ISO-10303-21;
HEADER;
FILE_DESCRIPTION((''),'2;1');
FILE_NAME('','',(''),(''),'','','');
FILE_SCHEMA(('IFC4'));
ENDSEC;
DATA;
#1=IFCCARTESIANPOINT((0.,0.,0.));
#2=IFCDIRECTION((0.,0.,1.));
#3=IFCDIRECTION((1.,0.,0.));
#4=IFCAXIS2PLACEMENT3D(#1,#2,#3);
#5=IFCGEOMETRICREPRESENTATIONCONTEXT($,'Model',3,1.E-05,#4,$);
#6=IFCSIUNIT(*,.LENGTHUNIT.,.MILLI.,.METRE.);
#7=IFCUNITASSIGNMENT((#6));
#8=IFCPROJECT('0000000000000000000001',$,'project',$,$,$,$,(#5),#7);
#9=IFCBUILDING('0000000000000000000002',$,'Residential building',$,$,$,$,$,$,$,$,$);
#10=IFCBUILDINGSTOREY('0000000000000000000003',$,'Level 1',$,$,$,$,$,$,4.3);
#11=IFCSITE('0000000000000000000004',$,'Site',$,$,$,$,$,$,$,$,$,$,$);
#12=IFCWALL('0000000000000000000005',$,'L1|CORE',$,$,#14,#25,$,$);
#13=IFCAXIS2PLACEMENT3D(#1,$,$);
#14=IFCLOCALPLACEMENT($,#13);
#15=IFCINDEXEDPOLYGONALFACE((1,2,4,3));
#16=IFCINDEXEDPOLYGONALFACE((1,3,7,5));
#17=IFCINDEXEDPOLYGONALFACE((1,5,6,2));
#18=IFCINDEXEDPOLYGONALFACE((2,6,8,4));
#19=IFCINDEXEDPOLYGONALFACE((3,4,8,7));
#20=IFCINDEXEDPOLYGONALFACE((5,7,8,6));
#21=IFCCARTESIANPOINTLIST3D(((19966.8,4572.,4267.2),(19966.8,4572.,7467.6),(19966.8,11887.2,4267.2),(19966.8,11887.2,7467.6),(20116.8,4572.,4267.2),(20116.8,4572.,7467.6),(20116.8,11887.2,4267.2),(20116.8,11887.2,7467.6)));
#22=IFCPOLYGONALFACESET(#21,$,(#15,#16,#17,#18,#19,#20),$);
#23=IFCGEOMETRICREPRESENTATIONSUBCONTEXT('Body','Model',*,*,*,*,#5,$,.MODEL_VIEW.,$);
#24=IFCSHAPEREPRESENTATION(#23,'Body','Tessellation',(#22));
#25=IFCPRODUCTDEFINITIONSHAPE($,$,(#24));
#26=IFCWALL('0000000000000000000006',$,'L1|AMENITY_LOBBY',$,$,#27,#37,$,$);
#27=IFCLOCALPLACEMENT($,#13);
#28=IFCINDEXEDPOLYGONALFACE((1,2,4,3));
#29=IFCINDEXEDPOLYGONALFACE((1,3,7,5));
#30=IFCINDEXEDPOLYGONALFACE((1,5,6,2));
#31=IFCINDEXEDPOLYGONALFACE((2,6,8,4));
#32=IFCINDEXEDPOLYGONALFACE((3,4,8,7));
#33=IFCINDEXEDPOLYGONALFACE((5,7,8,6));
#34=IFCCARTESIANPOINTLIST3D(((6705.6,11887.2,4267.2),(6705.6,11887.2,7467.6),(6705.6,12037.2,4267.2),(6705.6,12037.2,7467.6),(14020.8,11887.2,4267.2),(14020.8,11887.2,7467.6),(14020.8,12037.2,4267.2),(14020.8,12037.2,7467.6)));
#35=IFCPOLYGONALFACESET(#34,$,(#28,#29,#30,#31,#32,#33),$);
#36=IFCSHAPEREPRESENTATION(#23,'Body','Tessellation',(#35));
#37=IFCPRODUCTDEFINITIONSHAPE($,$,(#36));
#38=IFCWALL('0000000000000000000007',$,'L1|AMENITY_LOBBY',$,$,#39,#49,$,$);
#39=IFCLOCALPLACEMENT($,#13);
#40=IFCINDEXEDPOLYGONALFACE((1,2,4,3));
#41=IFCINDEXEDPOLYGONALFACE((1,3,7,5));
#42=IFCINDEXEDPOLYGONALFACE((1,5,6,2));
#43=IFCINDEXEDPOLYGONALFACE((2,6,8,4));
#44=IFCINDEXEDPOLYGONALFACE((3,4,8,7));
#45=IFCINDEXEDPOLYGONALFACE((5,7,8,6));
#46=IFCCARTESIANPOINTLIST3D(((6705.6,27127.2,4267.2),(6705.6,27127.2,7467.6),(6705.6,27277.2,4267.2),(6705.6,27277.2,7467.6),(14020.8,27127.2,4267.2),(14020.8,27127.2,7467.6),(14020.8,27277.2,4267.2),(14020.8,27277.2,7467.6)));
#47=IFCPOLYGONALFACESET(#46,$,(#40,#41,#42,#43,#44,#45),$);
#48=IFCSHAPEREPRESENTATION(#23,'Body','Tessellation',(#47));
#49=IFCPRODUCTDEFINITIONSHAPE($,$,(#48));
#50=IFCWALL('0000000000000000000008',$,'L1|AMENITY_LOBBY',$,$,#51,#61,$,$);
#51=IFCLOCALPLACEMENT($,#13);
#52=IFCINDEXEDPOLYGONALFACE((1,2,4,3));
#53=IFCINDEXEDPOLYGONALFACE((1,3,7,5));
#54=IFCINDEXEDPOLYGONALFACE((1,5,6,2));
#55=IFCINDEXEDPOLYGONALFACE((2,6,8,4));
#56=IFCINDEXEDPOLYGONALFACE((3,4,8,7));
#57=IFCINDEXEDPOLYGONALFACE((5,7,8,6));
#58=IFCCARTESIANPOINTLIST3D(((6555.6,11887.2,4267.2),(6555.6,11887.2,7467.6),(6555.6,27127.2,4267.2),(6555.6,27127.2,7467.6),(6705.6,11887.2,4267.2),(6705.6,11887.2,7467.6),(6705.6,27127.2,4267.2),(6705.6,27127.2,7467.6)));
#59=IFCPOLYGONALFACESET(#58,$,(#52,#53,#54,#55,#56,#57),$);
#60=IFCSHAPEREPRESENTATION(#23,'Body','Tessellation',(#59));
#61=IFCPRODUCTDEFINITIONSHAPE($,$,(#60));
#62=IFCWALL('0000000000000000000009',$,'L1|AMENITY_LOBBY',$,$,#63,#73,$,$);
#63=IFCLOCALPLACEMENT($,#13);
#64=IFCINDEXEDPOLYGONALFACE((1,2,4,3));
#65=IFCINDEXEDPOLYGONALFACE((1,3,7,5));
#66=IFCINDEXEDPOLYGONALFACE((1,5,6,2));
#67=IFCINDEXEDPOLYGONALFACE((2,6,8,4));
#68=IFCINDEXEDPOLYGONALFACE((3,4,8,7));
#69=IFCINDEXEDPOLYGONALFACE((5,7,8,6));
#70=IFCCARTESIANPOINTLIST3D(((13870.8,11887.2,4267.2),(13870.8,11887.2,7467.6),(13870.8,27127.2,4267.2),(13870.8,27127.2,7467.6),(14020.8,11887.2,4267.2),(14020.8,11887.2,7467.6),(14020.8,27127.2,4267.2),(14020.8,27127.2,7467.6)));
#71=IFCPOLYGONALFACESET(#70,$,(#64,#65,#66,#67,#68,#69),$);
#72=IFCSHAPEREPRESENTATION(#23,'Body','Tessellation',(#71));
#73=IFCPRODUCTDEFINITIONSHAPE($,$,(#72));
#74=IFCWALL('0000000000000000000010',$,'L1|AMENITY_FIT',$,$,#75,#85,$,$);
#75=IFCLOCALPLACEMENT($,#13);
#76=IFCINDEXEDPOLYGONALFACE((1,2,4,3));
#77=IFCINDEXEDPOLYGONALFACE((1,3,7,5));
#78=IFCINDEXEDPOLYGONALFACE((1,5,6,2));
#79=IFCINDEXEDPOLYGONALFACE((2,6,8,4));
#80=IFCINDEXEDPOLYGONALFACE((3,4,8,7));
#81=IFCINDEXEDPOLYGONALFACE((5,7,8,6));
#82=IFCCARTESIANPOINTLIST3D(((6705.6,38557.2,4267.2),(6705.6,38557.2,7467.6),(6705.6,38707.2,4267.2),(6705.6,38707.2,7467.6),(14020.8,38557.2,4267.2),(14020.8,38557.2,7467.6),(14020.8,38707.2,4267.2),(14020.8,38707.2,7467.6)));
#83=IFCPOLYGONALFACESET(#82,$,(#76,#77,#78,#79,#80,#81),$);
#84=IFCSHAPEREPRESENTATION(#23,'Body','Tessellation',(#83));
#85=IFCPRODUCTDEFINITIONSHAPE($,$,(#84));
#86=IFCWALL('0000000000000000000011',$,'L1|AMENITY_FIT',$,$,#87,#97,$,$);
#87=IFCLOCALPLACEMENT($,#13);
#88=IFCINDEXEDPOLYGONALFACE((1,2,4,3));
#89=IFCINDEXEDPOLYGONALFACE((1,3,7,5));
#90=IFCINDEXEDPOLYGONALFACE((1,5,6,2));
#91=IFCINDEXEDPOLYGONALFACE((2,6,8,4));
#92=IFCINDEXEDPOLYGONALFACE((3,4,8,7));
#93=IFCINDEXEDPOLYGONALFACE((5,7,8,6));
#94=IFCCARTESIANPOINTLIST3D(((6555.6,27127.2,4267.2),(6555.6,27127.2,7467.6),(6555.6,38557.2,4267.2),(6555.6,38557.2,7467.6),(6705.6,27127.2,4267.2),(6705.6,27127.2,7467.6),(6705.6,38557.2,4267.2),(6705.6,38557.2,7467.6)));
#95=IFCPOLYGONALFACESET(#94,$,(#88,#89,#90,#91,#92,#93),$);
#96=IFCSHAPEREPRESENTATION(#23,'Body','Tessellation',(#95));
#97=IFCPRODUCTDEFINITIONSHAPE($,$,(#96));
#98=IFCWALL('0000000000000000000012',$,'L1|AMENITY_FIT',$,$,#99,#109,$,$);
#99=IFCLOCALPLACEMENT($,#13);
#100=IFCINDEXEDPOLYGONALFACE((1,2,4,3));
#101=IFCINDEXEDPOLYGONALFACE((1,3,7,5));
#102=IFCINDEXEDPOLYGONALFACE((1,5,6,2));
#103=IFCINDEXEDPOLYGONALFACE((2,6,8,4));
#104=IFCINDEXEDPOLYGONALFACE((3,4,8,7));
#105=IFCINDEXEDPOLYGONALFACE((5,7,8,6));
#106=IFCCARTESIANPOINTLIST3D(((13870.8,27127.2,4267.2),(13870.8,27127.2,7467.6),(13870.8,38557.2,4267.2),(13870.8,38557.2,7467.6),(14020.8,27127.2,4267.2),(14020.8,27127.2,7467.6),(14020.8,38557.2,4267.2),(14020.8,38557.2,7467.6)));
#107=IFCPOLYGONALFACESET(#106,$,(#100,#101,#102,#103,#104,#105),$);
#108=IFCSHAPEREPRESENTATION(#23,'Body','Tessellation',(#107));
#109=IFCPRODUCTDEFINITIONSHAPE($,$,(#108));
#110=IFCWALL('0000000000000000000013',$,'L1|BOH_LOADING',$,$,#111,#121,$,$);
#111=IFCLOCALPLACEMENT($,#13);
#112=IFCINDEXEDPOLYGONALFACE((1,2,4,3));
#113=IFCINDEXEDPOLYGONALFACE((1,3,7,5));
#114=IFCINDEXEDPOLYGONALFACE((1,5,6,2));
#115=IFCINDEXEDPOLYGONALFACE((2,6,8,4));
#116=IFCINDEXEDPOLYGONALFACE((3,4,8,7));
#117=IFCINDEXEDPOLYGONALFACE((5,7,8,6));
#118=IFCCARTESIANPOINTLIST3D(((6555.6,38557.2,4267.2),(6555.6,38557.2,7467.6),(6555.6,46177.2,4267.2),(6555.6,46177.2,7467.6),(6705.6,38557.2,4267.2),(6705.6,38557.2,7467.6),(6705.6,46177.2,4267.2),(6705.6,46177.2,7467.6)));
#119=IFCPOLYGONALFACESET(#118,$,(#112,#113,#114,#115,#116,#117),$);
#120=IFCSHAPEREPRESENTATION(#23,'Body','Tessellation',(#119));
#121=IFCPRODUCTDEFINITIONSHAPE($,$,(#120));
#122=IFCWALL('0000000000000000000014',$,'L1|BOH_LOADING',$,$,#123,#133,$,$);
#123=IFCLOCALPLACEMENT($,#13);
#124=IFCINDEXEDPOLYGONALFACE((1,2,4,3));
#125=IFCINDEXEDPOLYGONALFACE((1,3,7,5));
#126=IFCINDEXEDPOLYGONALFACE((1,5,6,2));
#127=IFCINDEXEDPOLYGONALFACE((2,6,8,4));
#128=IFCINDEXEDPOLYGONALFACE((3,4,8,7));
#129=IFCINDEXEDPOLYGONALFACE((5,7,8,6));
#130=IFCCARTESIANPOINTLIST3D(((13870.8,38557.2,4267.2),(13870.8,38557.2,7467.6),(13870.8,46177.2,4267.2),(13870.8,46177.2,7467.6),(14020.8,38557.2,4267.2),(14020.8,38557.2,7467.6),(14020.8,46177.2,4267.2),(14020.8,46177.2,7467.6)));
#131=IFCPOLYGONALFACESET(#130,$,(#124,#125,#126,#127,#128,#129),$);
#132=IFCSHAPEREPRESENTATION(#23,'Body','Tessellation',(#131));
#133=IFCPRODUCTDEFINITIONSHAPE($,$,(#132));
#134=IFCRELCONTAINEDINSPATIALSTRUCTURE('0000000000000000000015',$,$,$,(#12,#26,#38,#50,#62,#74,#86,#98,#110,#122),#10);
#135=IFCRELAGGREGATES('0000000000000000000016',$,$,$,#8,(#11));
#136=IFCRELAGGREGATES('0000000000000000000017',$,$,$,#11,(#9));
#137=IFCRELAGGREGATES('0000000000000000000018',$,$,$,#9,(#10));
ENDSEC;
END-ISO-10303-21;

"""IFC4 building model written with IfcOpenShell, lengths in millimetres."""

from ifc_helpers import new_model, si_unit, frame, origin_with_axes, place, context, subcontext, project, spatial, indexed_curve, outline, extrude, element, save


model = new_model("IFC4")

# Units and contexts
model_context = context("Model", 3, precision=1e-05, world=origin_with_axes())
body_context = subcontext(model_context, "Body", "Model", "MODEL_VIEW")
ifc_project = project(units=[si_unit("LENGTHUNIT", "METRE", prefix="MILLI")], contexts=[model_context])

# Site, building, storey
site = spatial("IfcSite", under=ifc_project, Name="Site")
building = spatial("IfcBuilding", under=site, Name="Residential building")
storey = spatial("IfcBuildingStorey", under=building, Name="Level 1", Elevation=4.3)

# Walls
for number, where, z_axis, x_axis, name in (
    (1, (20116.8, 4572.0, 4267.2), (0.0, 0.0, 1.0), (0.0, 1.0, 0.0), "L1|CORE"),
    (2, (6705.6, 11887.2, 4267.2), (0.0, 0.0, 1.0), (1.0, 0.0, 0.0), "L1|AMENITY_LOBBY"),
    (3, (6705.6, 27127.2, 4267.2), (0.0, 0.0, 1.0), (1.0, 0.0, 0.0), "L1|AMENITY_LOBBY"),
):
    element("IfcWall", number, at=place(None, frame(where, z_axis=z_axis, x_axis=x_axis)), inside=storey, Name=name, context=body_context, shape_type="SweptSolid", body=[
        extrude(outline(indexed_curve([(0.0, 0.0), (0.0, 150.0), (7315.2, 150.0), (7315.2, 0.0), (0.0, 0.0)], self_intersect=False)), origin_with_axes(), (0.0, 0.0, 1.0), 3200.4),
    ])
for number, where, z_axis, x_axis, name in (
    (4, (6705.6, 11887.2, 4267.2), (0.0, 0.0, 1.0), (0.0, 1.0, 0.0), "L1|AMENITY_LOBBY"),
    (5, (14020.8, 11887.2, 4267.2), (0.0, 0.0, 1.0), (0.0, 1.0, 0.0), "L1|AMENITY_LOBBY"),
):
    element("IfcWall", number, at=place(None, frame(where, z_axis=z_axis, x_axis=x_axis)), inside=storey, Name=name, context=body_context, shape_type="SweptSolid", body=[
        extrude(outline(indexed_curve([(0.0, 0.0), (0.0, 150.0), (15240.0, 150.0), (15240.0, 0.0), (0.0, 0.0)], self_intersect=False)), origin_with_axes(), (0.0, 0.0, 1.0), 3200.4),
    ])
for number, where, z_axis, x_axis, name in (
    (6, (6705.6, 38557.2, 4267.2), (0.0, 0.0, 1.0), (1.0, 0.0, 0.0), "L1|AMENITY_FIT"),
):
    element("IfcWall", number, at=place(None, frame(where, z_axis=z_axis, x_axis=x_axis)), inside=storey, Name=name, context=body_context, shape_type="SweptSolid", body=[
        extrude(outline(indexed_curve([(0.0, 0.0), (0.0, 150.0), (7315.2, 150.0), (7315.2, 0.0), (0.0, 0.0)], self_intersect=False)), origin_with_axes(), (0.0, 0.0, 1.0), 3200.4),
    ])
for number, where, z_axis, x_axis, name in (
    (7, (6705.6, 27127.2, 4267.2), (0.0, 0.0, 1.0), (0.0, 1.0, 0.0), "L1|AMENITY_FIT"),
    (8, (14020.8, 27127.2, 4267.2), (0.0, 0.0, 1.0), (0.0, 1.0, 0.0), "L1|AMENITY_FIT"),
):
    element("IfcWall", number, at=place(None, frame(where, z_axis=z_axis, x_axis=x_axis)), inside=storey, Name=name, context=body_context, shape_type="SweptSolid", body=[
        extrude(outline(indexed_curve([(0.0, 0.0), (0.0, 150.0), (11430.0, 150.0), (11430.0, 0.0), (0.0, 0.0)], self_intersect=False)), origin_with_axes(), (0.0, 0.0, 1.0), 3200.4),
    ])
for number, where, z_axis, x_axis, name in (
    (9, (6705.6, 38557.2, 4267.2), (0.0, 0.0, 1.0), (0.0, 1.0, 0.0), "L1|BOH_LOADING"),
    (10, (14020.8, 38557.2, 4267.2), (0.0, 0.0, 1.0), (0.0, 1.0, 0.0), "L1|BOH_LOADING"),
):
    element("IfcWall", number, at=place(None, frame(where, z_axis=z_axis, x_axis=x_axis)), inside=storey, Name=name, context=body_context, shape_type="SweptSolid", body=[
        extrude(outline(indexed_curve([(0.0, 0.0), (0.0, 150.0), (7620.0, 150.0), (7620.0, 0.0), (0.0, 0.0)], self_intersect=False)), origin_with_axes(), (0.0, 0.0, 1.0), 3200.4),
    ])

save(model, "model.ifc")
